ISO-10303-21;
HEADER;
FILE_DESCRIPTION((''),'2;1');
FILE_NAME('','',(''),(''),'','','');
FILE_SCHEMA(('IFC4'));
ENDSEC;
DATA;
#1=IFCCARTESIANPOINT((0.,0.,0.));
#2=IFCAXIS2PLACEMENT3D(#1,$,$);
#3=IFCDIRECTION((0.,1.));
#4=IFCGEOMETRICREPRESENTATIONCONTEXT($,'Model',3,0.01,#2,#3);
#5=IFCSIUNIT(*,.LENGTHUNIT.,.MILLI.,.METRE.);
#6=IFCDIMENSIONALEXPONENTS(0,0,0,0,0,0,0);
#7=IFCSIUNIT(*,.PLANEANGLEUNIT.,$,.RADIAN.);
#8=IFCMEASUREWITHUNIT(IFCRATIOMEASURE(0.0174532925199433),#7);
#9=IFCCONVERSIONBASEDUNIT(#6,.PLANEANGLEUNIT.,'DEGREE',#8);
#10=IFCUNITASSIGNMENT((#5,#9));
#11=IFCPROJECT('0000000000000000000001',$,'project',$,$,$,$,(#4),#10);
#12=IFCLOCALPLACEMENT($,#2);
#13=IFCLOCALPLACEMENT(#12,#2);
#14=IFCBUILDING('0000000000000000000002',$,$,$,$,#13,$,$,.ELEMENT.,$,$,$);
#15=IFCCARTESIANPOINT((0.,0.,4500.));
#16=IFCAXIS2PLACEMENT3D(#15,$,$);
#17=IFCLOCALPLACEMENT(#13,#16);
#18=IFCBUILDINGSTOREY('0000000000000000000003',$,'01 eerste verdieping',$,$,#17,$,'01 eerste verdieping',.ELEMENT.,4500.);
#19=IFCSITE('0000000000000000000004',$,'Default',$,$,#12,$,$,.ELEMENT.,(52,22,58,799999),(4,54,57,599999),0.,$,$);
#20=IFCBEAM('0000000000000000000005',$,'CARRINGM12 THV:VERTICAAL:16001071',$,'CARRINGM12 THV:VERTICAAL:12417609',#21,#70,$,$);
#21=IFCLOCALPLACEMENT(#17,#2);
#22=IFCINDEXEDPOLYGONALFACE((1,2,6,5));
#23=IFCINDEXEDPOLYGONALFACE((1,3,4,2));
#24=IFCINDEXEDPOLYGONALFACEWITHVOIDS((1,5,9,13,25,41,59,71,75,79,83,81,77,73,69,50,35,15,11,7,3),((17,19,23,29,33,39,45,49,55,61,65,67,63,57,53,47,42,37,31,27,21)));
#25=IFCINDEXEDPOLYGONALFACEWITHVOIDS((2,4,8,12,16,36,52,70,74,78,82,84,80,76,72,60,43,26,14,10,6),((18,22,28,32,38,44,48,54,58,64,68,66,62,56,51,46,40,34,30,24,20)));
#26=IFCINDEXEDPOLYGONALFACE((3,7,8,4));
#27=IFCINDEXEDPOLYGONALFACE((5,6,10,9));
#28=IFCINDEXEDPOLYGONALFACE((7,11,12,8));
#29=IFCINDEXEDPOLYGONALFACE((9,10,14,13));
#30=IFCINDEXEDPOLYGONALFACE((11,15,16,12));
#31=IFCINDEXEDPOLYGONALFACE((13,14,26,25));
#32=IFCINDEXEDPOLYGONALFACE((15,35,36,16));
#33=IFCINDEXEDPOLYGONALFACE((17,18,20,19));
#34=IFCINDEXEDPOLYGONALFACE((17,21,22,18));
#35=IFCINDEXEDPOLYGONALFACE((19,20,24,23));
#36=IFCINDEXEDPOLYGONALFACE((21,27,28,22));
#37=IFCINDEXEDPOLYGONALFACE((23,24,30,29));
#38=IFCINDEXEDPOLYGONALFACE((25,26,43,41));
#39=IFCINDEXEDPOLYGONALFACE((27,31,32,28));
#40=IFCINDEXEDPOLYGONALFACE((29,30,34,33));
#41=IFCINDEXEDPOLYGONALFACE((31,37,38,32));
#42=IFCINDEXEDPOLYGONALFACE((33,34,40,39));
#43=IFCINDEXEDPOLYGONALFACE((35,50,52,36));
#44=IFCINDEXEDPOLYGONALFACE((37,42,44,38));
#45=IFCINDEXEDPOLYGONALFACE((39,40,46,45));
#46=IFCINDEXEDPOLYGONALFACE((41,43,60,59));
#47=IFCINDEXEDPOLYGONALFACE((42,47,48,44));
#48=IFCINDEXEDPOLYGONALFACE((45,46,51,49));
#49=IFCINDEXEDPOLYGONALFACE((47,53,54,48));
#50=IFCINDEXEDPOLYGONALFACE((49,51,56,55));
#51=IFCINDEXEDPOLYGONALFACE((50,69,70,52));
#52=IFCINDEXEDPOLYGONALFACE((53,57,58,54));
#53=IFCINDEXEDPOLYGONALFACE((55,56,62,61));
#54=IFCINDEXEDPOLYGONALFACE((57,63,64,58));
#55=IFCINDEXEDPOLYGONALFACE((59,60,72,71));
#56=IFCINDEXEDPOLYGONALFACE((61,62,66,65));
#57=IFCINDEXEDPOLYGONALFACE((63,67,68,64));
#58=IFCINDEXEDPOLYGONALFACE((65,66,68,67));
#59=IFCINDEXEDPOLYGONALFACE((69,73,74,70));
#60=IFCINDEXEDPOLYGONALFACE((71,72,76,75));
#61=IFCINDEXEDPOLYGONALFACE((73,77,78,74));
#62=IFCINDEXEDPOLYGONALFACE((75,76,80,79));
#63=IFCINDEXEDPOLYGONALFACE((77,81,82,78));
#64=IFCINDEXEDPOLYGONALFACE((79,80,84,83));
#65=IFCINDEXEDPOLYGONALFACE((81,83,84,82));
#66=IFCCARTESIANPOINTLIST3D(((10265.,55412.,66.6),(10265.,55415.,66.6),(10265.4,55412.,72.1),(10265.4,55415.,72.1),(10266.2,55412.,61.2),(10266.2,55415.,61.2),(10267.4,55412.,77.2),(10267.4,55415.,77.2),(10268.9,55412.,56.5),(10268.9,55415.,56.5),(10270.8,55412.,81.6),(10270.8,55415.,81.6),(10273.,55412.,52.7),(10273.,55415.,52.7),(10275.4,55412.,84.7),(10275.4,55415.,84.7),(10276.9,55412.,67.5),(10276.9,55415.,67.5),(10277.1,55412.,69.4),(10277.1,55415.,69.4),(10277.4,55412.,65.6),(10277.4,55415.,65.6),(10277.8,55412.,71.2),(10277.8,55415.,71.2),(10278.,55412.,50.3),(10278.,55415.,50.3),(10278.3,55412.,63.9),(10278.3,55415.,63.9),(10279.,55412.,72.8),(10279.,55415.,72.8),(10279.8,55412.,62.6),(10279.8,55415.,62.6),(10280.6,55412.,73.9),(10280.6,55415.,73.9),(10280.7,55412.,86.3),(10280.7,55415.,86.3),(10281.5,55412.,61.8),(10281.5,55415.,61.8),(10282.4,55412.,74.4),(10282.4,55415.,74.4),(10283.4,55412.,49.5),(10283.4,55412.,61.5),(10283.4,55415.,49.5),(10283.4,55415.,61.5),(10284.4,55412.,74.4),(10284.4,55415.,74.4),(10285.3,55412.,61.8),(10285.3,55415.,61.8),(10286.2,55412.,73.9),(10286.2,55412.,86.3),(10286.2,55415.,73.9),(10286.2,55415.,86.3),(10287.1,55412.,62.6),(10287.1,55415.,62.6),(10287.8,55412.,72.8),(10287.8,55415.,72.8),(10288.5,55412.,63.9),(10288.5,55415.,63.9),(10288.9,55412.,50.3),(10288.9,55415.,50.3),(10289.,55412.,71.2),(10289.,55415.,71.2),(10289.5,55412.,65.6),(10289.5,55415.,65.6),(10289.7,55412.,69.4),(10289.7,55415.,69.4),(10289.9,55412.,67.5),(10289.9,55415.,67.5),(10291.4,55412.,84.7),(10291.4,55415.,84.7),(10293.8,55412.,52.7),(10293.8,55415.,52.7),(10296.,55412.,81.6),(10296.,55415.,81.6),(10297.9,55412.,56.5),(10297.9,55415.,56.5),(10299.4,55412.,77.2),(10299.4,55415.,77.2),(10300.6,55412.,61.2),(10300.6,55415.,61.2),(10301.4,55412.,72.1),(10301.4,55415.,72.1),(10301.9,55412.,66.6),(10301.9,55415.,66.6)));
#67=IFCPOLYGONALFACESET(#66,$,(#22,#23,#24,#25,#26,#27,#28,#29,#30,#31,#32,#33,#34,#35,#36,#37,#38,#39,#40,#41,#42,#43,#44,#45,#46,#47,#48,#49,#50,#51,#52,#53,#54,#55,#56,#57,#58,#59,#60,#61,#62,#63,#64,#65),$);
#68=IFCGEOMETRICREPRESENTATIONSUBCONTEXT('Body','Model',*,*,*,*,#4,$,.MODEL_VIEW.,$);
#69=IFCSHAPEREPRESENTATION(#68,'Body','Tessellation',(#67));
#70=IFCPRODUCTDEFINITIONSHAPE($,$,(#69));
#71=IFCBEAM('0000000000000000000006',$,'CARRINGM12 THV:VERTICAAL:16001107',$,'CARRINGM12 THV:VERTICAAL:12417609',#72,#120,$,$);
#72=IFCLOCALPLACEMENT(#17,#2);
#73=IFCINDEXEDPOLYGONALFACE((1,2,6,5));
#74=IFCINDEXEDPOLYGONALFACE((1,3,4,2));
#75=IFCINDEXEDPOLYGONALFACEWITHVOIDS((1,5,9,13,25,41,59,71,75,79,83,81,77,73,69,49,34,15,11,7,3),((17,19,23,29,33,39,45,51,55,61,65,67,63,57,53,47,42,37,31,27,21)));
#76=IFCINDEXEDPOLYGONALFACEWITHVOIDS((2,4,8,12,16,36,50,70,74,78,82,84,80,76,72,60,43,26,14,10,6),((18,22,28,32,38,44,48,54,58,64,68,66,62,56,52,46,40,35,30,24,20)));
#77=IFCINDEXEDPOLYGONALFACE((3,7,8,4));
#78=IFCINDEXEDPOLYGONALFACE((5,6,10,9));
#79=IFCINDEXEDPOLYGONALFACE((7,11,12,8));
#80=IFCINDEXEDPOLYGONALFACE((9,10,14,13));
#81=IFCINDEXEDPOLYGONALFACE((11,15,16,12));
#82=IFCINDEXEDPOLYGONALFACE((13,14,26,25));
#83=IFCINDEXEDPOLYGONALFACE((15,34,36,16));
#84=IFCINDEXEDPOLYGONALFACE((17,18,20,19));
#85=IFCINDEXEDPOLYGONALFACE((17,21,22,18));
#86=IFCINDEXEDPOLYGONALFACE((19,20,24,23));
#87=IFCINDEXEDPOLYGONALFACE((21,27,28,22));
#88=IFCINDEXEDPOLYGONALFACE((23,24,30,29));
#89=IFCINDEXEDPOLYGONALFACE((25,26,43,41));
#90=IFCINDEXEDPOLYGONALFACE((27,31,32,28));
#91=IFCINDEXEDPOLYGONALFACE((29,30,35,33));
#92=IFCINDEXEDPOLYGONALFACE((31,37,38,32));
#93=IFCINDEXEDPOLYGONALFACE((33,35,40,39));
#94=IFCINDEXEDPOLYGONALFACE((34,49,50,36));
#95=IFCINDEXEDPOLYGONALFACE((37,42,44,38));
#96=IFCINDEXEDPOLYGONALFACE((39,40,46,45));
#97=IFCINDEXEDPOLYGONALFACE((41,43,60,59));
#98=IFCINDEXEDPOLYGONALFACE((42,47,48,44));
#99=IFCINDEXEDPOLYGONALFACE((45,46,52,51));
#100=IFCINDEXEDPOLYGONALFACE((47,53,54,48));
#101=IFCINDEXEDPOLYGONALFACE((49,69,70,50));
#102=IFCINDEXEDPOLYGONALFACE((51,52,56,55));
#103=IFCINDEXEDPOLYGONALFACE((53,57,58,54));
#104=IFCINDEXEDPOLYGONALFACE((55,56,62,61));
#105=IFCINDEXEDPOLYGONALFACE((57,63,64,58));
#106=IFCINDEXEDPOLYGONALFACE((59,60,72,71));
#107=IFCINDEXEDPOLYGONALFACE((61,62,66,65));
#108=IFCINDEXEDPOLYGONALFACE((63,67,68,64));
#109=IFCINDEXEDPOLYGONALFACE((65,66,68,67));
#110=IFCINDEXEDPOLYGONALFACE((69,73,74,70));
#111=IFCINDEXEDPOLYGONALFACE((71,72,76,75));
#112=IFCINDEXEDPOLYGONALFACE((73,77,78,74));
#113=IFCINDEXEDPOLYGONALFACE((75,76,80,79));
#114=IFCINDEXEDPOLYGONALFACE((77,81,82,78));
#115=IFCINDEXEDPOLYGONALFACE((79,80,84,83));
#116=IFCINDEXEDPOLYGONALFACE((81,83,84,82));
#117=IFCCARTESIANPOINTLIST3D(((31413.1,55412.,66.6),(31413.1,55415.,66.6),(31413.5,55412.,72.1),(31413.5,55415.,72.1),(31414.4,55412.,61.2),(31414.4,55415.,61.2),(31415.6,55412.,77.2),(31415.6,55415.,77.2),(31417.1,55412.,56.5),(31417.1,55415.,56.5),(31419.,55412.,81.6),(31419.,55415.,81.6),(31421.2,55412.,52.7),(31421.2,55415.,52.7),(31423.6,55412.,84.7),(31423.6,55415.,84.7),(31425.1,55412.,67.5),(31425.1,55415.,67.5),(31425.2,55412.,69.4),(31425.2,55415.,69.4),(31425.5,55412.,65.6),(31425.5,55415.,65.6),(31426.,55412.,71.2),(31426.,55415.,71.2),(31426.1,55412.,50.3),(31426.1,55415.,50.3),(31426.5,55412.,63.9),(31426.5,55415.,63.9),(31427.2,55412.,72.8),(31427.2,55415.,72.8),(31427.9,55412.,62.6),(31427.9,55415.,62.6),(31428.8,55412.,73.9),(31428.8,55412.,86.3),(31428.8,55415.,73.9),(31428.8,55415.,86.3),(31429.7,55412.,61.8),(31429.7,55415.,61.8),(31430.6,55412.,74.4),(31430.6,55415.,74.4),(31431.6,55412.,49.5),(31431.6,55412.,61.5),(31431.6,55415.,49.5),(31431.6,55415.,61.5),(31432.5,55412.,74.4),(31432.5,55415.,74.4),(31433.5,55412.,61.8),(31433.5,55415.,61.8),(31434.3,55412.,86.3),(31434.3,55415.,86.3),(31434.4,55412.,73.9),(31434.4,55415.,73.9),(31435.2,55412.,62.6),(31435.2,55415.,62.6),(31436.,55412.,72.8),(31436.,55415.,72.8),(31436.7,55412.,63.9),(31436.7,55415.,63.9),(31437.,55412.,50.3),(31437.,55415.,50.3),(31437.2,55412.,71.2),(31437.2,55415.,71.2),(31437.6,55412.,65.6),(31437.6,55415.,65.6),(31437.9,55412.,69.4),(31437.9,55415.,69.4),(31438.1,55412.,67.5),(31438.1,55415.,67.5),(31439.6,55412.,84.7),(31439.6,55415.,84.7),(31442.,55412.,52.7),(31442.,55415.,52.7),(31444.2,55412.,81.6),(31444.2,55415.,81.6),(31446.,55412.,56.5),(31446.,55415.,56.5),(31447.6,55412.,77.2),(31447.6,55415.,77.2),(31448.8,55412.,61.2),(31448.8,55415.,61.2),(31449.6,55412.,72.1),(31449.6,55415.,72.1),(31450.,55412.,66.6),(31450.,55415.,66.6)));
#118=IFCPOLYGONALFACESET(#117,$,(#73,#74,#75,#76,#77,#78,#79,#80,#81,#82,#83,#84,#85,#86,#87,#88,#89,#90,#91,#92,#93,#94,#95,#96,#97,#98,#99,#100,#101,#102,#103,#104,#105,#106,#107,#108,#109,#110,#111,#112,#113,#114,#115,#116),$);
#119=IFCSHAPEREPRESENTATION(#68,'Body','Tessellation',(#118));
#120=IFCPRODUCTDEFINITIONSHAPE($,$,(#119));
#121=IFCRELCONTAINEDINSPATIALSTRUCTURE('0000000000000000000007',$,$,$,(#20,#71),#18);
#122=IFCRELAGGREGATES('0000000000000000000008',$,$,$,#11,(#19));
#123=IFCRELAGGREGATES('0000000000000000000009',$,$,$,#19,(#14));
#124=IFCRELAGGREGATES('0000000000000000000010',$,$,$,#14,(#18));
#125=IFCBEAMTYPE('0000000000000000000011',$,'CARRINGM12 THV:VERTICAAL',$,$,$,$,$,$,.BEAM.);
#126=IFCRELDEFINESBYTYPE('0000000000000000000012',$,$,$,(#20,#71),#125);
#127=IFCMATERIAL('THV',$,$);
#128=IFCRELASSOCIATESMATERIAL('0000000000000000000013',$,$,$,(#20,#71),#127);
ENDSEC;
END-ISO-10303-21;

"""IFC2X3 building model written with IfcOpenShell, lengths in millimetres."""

from ifc_helpers import new_model, entity, si_unit, converted_unit, direction, frame, origin, origin_2d_with_axis, place, context, subcontext, project, spatial, hollow_circle, extrude, material, type_object, element, save


model = new_model("IFC2X3")

# Units and contexts
model_context = context("Model", 3, precision=0.01, world=origin(), true_north=direction((0.0, 1.0)))
body_context = subcontext(model_context, "Body", "Model", "MODEL_VIEW")
ifc_project = project(units=[si_unit("LENGTHUNIT", "METRE", prefix="MILLI"), converted_unit("PLANEANGLEUNIT", "DEGREE", entity("IfcRatioMeasure", 0.0174532925199433), si_unit("PLANEANGLEUNIT", "RADIAN"), dimensions=[0, 0, 0, 0, 0, 0, 0])], contexts=[model_context])

# Site, building, storey
site_placement = place(None, origin())
site = spatial("IfcSite", under=ifc_project, at=site_placement, Name="Default", CompositionType="ELEMENT", RefLatitude=(52, 22, 58, 799999), RefLongitude=(4, 54, 57, 599999), RefElevation=0.0)
building_placement = place(site_placement, origin())
building = spatial("IfcBuilding", under=site, at=building_placement, CompositionType="ELEMENT")
storey_placement = place(building_placement, frame((0.0, 0.0, 4500.0)))
storey = spatial("IfcBuildingStorey", under=building, at=storey_placement, Name="01 eerste verdieping", LongName="01 eerste verdieping", CompositionType="ELEMENT", Elevation=4500.0)

# Beams
ifc_material_1 = material(Name="THV")
beam_type_1 = type_object("IfcBeamType", Name="CARRINGM12 THV:VERTICAAL", PredefinedType="BEAM")
beam_1_placement = place(storey_placement, origin())
element("IfcBeam", 1, at=beam_1_placement, inside=storey, type_object=beam_type_1, material=ifc_material_1, Name="CARRINGM12 THV:VERTICAAL:16001071", ObjectType="CARRINGM12 THV:VERTICAAL:12417609", context=body_context, shape_type="SweptSolid", body=[
    extrude(hollow_circle(Radius=18.5, WallThickness=12.0, at=origin_2d_with_axis()), frame((10283.4, 55412.0, 68.0), z_axis=(0.0, 1.0, 0.0), x_axis=(0.0, 0.0, -1.0)), (0.0, 0.0, 1.0), 3.0),
])
beam_2_placement = place(storey_placement, origin())
element("IfcBeam", 2, at=beam_2_placement, inside=storey, type_object=beam_type_1, material=ifc_material_1, Name="CARRINGM12 THV:VERTICAAL:16001107", ObjectType="CARRINGM12 THV:VERTICAAL:12417609", context=body_context, shape_type="SweptSolid", body=[
    extrude(hollow_circle(Radius=18.5, WallThickness=12.0, at=origin_2d_with_axis()), frame((31431.6, 55412.0, 68.0), z_axis=(0.0, 1.0, 0.0), x_axis=(0.0, 0.0, -1.0)), (0.0, 0.0, 1.0), 3.0),
])

save(model, "model.ifc")
